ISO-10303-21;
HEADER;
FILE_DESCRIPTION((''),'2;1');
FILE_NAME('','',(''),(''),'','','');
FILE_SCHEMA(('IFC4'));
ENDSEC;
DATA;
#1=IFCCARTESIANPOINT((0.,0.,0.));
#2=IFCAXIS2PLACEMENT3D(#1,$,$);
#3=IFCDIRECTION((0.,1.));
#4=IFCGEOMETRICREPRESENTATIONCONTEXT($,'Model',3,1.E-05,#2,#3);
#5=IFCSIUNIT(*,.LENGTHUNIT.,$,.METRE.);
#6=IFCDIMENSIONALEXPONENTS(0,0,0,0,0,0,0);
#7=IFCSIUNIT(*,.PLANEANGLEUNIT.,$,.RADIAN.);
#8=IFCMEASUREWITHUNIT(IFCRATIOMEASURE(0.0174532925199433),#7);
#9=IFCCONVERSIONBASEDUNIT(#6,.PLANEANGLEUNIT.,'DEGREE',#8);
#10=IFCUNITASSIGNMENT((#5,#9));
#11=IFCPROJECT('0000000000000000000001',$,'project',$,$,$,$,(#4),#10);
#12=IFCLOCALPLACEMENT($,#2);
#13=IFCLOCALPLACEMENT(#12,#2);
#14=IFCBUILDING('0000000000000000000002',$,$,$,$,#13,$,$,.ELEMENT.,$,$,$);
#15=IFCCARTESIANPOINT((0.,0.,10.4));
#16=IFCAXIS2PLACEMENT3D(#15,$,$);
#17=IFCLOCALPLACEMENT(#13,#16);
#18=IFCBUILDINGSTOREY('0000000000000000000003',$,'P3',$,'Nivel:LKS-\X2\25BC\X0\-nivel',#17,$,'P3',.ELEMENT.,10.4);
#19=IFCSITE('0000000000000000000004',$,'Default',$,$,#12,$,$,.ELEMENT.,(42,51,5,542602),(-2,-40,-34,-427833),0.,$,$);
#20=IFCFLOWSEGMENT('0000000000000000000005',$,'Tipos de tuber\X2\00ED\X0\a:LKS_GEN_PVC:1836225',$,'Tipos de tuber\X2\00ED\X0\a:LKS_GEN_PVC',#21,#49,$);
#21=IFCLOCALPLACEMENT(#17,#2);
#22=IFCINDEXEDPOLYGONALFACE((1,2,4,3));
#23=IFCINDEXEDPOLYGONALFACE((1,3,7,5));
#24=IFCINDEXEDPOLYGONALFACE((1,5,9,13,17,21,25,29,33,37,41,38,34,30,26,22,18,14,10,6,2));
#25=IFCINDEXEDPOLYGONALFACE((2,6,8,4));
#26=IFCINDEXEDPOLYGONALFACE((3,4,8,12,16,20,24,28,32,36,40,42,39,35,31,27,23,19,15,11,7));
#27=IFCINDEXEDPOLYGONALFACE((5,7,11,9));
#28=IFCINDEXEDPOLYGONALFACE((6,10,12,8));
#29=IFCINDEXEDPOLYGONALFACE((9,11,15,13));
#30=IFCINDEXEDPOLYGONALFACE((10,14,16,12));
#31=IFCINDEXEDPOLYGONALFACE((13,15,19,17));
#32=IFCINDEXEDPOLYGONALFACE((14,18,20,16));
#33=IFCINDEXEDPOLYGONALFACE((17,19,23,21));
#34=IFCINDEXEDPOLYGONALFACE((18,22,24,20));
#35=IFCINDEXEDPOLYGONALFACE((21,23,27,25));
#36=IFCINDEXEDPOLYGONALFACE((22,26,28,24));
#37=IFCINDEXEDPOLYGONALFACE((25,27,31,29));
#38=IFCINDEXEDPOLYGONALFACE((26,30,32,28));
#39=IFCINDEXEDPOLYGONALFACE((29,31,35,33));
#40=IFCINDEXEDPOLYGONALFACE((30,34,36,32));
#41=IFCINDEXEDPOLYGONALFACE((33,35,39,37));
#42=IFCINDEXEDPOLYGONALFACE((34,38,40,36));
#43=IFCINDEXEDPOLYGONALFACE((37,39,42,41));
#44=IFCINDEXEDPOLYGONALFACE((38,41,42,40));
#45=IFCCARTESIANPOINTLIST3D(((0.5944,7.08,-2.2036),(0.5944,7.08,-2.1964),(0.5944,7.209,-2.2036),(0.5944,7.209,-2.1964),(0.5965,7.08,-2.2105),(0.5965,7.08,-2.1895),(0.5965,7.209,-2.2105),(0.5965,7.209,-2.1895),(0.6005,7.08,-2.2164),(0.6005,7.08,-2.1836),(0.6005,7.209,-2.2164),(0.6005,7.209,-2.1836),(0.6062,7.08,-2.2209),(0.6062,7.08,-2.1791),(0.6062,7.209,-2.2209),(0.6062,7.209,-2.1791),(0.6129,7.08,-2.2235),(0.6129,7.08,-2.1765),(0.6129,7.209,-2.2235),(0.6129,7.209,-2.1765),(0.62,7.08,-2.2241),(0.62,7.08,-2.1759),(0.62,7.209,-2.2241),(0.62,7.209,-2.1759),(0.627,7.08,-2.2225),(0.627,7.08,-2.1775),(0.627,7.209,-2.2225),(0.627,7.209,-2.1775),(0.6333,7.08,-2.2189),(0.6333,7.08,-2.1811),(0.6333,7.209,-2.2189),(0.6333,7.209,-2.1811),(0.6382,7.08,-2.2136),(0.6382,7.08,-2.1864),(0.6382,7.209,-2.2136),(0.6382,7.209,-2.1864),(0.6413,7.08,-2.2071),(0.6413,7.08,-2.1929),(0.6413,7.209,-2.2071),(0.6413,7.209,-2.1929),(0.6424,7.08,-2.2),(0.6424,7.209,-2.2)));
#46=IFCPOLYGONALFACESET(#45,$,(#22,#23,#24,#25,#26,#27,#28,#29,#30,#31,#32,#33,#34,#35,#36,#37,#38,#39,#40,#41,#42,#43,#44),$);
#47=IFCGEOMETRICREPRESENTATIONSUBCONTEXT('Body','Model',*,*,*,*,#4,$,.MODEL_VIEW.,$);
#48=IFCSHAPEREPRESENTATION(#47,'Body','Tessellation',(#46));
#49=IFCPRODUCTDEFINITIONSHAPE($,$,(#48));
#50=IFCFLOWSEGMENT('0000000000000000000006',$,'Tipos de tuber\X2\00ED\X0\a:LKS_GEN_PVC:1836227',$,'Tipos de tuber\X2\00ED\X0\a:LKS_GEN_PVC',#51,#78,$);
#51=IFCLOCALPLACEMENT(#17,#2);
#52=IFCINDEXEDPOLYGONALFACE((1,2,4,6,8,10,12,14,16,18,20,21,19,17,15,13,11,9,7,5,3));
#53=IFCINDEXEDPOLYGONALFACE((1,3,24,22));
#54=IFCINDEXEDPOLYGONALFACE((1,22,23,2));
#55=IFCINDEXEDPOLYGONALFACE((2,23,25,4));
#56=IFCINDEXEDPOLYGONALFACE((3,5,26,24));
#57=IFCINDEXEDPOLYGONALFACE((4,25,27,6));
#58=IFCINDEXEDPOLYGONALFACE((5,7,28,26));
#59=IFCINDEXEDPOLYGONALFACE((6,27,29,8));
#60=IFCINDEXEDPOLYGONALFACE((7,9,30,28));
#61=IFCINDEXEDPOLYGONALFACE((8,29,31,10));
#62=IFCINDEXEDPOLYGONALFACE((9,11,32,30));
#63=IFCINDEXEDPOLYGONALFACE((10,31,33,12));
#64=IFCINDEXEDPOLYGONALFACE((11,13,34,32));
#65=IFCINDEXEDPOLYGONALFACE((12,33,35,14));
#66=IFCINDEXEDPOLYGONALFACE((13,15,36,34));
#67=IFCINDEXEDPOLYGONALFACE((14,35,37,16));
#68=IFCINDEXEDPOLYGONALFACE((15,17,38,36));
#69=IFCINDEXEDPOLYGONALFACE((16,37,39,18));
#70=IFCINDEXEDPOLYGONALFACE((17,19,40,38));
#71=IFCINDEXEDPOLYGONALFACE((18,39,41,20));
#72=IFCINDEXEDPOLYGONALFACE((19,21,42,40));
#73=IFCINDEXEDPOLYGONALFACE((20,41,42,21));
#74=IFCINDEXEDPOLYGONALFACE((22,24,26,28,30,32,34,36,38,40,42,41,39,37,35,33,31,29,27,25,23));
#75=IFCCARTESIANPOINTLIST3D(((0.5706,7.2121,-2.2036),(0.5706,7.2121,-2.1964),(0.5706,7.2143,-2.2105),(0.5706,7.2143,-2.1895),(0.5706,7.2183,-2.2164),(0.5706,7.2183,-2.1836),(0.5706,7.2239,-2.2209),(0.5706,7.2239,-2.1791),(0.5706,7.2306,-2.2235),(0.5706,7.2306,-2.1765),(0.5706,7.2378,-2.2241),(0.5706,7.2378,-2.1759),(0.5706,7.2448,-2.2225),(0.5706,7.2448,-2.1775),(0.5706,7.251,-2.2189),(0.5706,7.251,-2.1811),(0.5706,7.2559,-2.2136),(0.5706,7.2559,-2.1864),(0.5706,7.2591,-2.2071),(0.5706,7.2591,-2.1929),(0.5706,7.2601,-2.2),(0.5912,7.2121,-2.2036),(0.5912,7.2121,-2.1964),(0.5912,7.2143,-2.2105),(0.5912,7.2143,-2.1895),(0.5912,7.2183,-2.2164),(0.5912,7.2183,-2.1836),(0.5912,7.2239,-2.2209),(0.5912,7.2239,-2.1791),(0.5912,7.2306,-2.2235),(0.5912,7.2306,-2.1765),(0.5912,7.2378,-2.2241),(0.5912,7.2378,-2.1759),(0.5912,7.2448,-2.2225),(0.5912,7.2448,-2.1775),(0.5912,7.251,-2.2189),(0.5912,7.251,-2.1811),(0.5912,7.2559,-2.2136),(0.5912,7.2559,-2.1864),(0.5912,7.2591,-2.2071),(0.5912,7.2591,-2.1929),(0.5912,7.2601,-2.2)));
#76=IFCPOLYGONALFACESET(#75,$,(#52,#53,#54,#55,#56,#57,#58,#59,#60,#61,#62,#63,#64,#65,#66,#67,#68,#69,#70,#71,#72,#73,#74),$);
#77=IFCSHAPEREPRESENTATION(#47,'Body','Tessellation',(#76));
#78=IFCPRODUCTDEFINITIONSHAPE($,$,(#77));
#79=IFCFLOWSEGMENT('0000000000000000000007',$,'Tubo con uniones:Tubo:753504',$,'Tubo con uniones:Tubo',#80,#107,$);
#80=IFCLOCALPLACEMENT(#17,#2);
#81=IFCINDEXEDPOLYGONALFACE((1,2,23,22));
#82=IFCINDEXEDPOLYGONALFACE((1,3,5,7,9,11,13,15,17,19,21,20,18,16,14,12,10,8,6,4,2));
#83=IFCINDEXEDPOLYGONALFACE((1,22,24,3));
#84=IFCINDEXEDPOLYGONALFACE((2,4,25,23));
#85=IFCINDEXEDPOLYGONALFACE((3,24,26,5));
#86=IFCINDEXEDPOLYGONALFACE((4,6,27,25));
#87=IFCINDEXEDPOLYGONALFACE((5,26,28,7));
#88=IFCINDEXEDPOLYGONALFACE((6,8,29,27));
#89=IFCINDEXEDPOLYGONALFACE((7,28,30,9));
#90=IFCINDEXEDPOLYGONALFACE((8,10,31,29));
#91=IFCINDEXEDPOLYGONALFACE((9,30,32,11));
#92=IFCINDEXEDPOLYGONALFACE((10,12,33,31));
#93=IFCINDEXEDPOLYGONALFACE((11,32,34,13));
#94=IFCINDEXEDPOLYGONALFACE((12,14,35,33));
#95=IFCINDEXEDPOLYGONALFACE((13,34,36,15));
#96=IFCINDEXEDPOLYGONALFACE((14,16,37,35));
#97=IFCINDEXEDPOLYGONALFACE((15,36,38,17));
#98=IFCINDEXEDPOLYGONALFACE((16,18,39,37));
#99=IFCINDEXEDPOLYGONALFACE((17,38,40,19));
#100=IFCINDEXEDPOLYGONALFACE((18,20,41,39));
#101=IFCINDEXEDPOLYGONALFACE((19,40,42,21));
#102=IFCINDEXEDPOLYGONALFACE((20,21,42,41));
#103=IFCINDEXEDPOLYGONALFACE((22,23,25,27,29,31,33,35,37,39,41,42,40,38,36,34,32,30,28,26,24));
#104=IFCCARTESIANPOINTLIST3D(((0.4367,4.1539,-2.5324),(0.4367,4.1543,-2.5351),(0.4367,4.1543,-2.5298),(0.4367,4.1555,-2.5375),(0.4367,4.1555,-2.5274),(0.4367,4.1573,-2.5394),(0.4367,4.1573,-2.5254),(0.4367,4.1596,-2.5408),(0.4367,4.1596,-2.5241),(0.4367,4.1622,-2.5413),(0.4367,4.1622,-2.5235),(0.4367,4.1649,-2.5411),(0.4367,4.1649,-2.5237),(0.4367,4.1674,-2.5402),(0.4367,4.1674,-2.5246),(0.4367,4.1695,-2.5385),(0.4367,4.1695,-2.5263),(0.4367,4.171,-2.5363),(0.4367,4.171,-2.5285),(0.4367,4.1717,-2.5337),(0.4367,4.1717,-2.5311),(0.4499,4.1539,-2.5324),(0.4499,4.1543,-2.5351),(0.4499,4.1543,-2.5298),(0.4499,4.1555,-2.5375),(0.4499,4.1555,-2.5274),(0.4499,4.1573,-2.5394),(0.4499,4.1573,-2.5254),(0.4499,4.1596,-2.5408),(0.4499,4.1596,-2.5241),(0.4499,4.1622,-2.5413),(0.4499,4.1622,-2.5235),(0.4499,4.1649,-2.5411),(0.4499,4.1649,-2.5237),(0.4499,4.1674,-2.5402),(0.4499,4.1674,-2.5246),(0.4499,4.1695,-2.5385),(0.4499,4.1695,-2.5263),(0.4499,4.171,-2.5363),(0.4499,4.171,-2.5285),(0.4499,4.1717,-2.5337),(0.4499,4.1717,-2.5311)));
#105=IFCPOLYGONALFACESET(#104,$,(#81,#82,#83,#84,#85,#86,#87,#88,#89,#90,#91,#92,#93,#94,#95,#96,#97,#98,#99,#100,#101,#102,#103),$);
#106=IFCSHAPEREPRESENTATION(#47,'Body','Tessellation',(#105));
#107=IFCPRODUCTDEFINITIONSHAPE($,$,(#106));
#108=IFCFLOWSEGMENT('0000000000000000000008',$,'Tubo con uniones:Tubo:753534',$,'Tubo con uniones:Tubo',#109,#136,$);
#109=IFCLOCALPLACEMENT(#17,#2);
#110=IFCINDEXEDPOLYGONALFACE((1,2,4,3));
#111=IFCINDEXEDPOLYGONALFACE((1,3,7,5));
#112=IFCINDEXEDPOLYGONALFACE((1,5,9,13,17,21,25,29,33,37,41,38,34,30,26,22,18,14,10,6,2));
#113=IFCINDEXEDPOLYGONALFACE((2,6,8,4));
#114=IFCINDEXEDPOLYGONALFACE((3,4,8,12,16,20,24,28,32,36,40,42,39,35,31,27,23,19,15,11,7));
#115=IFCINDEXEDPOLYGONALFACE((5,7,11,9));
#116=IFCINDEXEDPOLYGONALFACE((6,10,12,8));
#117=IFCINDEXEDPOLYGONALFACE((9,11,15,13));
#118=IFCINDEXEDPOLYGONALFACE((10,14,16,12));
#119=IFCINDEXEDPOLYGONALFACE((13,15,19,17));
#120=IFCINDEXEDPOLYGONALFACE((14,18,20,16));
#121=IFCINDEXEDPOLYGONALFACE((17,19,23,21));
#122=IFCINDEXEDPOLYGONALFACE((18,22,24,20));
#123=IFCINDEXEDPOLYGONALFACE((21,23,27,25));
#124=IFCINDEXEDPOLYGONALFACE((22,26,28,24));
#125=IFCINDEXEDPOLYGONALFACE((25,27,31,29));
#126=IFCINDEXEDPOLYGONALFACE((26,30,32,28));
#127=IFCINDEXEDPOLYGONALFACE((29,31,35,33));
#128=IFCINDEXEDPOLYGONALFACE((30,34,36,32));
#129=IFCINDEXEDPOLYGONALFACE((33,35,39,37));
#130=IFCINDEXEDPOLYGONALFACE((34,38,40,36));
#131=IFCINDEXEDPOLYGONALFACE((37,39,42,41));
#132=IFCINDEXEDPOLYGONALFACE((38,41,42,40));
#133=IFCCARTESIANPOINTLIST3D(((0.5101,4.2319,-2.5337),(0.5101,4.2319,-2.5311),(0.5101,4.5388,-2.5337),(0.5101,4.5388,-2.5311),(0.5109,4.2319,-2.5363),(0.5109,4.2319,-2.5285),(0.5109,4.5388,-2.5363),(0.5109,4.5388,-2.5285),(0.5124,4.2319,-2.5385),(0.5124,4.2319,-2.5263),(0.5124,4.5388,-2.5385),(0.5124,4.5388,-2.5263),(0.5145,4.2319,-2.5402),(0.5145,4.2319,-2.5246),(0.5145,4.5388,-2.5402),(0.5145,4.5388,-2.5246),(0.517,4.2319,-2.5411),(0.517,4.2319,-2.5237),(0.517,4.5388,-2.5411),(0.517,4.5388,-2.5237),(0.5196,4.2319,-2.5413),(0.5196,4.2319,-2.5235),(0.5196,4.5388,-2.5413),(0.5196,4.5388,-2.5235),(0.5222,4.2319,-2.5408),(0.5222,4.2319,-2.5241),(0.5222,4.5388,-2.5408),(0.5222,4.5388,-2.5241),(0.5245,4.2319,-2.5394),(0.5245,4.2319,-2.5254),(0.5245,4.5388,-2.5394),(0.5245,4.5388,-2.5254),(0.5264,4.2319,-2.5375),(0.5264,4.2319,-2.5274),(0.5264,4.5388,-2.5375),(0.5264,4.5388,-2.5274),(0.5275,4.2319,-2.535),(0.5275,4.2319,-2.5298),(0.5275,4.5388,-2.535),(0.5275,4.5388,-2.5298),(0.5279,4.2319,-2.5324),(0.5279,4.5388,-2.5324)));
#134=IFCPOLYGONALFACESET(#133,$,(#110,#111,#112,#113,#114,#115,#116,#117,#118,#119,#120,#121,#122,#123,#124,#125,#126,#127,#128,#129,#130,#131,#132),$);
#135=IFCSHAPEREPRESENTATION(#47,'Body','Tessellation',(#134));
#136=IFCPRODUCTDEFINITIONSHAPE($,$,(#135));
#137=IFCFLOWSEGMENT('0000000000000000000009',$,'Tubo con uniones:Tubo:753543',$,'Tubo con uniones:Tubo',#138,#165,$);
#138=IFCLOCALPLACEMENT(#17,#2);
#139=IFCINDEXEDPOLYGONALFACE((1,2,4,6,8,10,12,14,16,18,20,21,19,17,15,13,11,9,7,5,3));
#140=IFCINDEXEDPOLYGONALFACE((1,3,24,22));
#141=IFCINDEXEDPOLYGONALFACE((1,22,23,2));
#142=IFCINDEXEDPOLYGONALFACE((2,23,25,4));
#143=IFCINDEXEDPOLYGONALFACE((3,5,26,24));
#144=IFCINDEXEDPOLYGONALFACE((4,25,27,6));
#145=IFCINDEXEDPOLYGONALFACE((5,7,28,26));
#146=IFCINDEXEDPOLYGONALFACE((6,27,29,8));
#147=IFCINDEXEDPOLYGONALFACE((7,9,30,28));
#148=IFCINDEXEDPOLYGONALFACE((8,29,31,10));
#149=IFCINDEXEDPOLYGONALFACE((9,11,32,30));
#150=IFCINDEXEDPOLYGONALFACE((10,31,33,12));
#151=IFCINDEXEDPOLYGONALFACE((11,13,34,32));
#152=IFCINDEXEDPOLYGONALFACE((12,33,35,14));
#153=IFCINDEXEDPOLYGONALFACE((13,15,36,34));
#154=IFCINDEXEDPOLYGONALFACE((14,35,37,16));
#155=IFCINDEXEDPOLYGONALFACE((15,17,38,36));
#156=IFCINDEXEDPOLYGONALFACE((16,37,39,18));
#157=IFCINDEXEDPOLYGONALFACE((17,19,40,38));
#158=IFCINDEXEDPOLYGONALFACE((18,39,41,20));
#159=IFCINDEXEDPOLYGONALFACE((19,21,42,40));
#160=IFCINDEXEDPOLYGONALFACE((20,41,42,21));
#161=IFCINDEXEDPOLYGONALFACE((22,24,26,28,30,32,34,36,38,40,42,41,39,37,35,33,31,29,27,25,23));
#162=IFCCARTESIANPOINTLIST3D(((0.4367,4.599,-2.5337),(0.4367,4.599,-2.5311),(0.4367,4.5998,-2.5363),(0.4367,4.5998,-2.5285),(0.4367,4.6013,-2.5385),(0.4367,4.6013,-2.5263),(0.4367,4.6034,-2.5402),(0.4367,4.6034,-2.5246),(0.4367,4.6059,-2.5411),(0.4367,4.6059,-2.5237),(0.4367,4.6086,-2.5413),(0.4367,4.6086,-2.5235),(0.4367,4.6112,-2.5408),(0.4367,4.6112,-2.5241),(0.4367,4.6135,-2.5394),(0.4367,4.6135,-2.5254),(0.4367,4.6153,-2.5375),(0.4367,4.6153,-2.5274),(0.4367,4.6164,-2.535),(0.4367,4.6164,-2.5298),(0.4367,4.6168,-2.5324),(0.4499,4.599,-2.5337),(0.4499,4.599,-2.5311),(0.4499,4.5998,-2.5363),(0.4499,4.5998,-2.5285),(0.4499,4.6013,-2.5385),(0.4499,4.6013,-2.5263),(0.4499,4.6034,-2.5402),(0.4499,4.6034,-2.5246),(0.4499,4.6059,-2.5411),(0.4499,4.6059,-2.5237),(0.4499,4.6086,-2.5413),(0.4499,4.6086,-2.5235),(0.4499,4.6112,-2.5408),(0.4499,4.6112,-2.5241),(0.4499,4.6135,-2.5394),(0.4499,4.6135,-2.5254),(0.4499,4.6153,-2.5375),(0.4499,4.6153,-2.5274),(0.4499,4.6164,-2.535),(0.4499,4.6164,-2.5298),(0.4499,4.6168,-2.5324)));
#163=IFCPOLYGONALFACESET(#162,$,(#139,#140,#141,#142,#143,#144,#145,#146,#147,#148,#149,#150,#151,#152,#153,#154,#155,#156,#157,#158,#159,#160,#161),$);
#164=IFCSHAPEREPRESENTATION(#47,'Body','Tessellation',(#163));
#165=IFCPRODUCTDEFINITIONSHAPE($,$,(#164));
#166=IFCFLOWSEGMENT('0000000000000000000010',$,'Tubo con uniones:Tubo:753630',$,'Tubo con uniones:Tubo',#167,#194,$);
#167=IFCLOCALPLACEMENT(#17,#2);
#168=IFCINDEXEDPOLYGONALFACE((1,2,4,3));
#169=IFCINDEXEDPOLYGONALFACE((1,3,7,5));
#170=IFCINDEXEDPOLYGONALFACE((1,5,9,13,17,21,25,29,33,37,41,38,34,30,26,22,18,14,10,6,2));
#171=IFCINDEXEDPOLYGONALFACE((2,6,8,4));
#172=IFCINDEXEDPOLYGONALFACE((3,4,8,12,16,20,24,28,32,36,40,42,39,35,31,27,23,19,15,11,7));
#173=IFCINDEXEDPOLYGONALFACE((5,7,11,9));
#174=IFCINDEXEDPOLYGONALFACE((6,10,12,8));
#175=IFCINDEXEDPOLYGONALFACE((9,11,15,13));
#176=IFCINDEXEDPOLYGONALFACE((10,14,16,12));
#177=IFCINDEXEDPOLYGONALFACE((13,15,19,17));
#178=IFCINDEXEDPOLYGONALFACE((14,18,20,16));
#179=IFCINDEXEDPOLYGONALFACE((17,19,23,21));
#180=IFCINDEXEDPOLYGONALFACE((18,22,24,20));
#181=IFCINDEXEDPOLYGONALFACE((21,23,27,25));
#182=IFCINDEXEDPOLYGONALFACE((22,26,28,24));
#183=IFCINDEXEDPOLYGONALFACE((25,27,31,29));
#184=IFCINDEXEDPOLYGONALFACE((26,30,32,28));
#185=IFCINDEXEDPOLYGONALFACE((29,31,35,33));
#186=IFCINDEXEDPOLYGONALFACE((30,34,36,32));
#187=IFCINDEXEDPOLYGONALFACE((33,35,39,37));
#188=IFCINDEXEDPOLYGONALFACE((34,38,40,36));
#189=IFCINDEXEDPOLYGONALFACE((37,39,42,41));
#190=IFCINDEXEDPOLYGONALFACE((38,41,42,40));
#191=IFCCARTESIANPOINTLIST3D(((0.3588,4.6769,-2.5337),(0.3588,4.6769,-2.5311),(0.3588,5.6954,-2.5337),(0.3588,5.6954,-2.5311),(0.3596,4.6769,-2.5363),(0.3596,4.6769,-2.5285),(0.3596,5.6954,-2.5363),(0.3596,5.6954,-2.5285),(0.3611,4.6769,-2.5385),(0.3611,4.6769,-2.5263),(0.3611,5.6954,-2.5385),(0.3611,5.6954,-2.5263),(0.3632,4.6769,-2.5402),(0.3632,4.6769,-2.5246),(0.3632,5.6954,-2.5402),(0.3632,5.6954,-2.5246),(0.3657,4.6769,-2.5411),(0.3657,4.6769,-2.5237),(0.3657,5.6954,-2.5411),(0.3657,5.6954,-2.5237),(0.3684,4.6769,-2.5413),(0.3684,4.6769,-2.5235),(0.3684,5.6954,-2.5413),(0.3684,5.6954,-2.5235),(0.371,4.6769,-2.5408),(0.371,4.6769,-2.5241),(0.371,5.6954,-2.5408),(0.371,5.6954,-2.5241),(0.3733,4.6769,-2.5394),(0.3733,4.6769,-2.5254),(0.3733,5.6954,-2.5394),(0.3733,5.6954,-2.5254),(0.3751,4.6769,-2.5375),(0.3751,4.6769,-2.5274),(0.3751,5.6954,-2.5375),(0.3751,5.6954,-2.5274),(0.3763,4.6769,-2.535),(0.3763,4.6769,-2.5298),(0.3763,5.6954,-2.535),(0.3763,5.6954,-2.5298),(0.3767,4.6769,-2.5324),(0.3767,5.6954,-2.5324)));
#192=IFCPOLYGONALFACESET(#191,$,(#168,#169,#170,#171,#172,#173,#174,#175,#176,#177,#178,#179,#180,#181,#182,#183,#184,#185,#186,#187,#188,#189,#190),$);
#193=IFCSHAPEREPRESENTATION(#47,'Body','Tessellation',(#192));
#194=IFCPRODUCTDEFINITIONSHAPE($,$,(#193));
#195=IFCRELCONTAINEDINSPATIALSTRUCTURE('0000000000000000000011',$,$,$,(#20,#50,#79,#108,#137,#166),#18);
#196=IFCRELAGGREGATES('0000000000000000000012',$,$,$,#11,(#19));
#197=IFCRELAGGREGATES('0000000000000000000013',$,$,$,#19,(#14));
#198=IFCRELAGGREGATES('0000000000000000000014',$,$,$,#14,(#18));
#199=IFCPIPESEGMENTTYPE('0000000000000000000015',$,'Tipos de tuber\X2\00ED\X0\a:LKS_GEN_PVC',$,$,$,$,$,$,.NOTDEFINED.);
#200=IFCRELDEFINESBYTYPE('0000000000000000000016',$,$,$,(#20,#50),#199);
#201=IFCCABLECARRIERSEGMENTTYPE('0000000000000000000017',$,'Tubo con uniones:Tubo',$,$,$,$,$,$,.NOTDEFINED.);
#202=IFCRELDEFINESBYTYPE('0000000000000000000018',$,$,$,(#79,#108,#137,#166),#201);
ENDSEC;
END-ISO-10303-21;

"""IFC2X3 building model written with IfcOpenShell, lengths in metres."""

from ifc_helpers import new_model, entity, si_unit, converted_unit, direction, frame, frame_2d, origin, origin_2d_with_axis, place, context, subcontext, project, spatial, circle, extrude, type_object, element, save


model = new_model("IFC2X3")

# Units and contexts
model_context = context("Model", 3, precision=1e-05, world=origin(), true_north=direction((0.0, 1.0)))
body_context = subcontext(model_context, "Body", "Model", "MODEL_VIEW")
ifc_project = project(units=[si_unit("LENGTHUNIT", "METRE"), converted_unit("PLANEANGLEUNIT", "DEGREE", entity("IfcRatioMeasure", 0.0174532925199433), si_unit("PLANEANGLEUNIT", "RADIAN"), dimensions=[0, 0, 0, 0, 0, 0, 0])], contexts=[model_context])

# Site, building, storey
site_placement = place(None, origin())
site = spatial("IfcSite", under=ifc_project, at=site_placement, Name="Default", CompositionType="ELEMENT", RefLatitude=(42, 51, 5, 542602), RefLongitude=(-2, -40, -34, -427833), RefElevation=0.0)
building_placement = place(site_placement, origin())
building = spatial("IfcBuilding", under=site, at=building_placement, CompositionType="ELEMENT")
storey_placement = place(building_placement, frame((0.0, 0.0, 10.4)))
storey = spatial("IfcBuildingStorey", under=building, at=storey_placement, Name="P3", ObjectType="Nivel:LKS-▼-nivel", LongName="P3", CompositionType="ELEMENT", Elevation=10.4)

# Flow segments
pipe_segment_type_1 = type_object("IfcPipeSegmentType", Name="Tipos de tubería:LKS_GEN_PVC", PredefinedType="NOTDEFINED")
flow_segment_1_placement = place(storey_placement, origin())
element("IfcFlowSegment", 1, at=flow_segment_1_placement, inside=storey, type_object=pipe_segment_type_1, Name="Tipos de tubería:LKS_GEN_PVC:1836225", ObjectType="Tipos de tubería:LKS_GEN_PVC", context=body_context, shape_type="SweptSolid", body=[
    extrude(circle(Radius=0.0241, at=frame_2d((0.0, 0.0), x_axis=(1.0, 0.0))), frame((0.6182, 7.08, -2.2), z_axis=(0.0, 1.0, 0.0), x_axis=(1.0, 0.0, 0.0)), (0.0, 0.0, 1.0), 0.129),
])
flow_segment_2_placement = place(storey_placement, origin())
element("IfcFlowSegment", 2, at=flow_segment_2_placement, inside=storey, type_object=pipe_segment_type_1, Name="Tipos de tubería:LKS_GEN_PVC:1836227", ObjectType="Tipos de tubería:LKS_GEN_PVC", context=body_context, shape_type="SweptSolid", body=[
    extrude(circle(Radius=0.0241, at=origin_2d_with_axis()), frame((0.5706, 7.236, -2.2), z_axis=(1.0, 0.0, 0.0), x_axis=(0.0, 1.0, 0.0)), (0.0, 0.0, 1.0), 0.0206),
])
cable_carrier_segment_type = type_object("IfcCableCarrierSegmentType", Name="Tubo con uniones:Tubo", PredefinedType="NOTDEFINED")
flow_segment_3_placement = place(storey_placement, origin())
element("IfcFlowSegment", 3, at=flow_segment_3_placement, inside=storey, type_object=cable_carrier_segment_type, Name="Tubo con uniones:Tubo:753504", ObjectType="Tubo con uniones:Tubo", context=body_context, shape_type="SweptSolid", body=[
    extrude(circle(Radius=0.009, at=frame_2d((0.0, 0.0), x_axis=(1.0, 0.0))), frame((0.4367, 4.1629, -2.5324), z_axis=(1.0, 0.0, 0.0), x_axis=(0.0, -1.0, 0.0)), (0.0, 0.0, 1.0), 0.0132),
])
flow_segment_4_placement = place(storey_placement, origin())
element("IfcFlowSegment", 4, at=flow_segment_4_placement, inside=storey, type_object=cable_carrier_segment_type, Name="Tubo con uniones:Tubo:753534", ObjectType="Tubo con uniones:Tubo", context=body_context, shape_type="SweptSolid", body=[
    extrude(circle(Radius=0.009, at=origin_2d_with_axis()), frame((0.519, 4.2319, -2.5324), z_axis=(0.0, 1.0, 0.0), x_axis=(1.0, 0.0, 0.000038)), (0.0, 0.0, 1.0), 0.3069),
])
flow_segment_5_placement = place(storey_placement, origin())
element("IfcFlowSegment", 5, at=flow_segment_5_placement, inside=storey, type_object=cable_carrier_segment_type, Name="Tubo con uniones:Tubo:753543", ObjectType="Tubo con uniones:Tubo", context=body_context, shape_type="SweptSolid", body=[
    extrude(circle(Radius=0.009, at=origin_2d_with_axis()), frame((0.4367, 4.6079, -2.5324), z_axis=(1.0, 0.0, 0.0), x_axis=(0.0, 1.0, 0.0)), (0.0, 0.0, 1.0), 0.0132),
])
flow_segment_6_placement = place(storey_placement, origin())
element("IfcFlowSegment", 6, at=flow_segment_6_placement, inside=storey, type_object=cable_carrier_segment_type, Name="Tubo con uniones:Tubo:753630", ObjectType="Tubo con uniones:Tubo", context=body_context, shape_type="SweptSolid", body=[
    extrude(circle(Radius=0.009, at=frame_2d((0.0, 0.0), x_axis=(1.0, 0.0))), frame((0.3677, 4.6769, -2.5324), z_axis=(0.0, 1.0, 0.0), x_axis=(1.0, 0.0, 0.0)), (0.0, 0.0, 1.0), 1.0185),
])

save(model, "model.ifc")
